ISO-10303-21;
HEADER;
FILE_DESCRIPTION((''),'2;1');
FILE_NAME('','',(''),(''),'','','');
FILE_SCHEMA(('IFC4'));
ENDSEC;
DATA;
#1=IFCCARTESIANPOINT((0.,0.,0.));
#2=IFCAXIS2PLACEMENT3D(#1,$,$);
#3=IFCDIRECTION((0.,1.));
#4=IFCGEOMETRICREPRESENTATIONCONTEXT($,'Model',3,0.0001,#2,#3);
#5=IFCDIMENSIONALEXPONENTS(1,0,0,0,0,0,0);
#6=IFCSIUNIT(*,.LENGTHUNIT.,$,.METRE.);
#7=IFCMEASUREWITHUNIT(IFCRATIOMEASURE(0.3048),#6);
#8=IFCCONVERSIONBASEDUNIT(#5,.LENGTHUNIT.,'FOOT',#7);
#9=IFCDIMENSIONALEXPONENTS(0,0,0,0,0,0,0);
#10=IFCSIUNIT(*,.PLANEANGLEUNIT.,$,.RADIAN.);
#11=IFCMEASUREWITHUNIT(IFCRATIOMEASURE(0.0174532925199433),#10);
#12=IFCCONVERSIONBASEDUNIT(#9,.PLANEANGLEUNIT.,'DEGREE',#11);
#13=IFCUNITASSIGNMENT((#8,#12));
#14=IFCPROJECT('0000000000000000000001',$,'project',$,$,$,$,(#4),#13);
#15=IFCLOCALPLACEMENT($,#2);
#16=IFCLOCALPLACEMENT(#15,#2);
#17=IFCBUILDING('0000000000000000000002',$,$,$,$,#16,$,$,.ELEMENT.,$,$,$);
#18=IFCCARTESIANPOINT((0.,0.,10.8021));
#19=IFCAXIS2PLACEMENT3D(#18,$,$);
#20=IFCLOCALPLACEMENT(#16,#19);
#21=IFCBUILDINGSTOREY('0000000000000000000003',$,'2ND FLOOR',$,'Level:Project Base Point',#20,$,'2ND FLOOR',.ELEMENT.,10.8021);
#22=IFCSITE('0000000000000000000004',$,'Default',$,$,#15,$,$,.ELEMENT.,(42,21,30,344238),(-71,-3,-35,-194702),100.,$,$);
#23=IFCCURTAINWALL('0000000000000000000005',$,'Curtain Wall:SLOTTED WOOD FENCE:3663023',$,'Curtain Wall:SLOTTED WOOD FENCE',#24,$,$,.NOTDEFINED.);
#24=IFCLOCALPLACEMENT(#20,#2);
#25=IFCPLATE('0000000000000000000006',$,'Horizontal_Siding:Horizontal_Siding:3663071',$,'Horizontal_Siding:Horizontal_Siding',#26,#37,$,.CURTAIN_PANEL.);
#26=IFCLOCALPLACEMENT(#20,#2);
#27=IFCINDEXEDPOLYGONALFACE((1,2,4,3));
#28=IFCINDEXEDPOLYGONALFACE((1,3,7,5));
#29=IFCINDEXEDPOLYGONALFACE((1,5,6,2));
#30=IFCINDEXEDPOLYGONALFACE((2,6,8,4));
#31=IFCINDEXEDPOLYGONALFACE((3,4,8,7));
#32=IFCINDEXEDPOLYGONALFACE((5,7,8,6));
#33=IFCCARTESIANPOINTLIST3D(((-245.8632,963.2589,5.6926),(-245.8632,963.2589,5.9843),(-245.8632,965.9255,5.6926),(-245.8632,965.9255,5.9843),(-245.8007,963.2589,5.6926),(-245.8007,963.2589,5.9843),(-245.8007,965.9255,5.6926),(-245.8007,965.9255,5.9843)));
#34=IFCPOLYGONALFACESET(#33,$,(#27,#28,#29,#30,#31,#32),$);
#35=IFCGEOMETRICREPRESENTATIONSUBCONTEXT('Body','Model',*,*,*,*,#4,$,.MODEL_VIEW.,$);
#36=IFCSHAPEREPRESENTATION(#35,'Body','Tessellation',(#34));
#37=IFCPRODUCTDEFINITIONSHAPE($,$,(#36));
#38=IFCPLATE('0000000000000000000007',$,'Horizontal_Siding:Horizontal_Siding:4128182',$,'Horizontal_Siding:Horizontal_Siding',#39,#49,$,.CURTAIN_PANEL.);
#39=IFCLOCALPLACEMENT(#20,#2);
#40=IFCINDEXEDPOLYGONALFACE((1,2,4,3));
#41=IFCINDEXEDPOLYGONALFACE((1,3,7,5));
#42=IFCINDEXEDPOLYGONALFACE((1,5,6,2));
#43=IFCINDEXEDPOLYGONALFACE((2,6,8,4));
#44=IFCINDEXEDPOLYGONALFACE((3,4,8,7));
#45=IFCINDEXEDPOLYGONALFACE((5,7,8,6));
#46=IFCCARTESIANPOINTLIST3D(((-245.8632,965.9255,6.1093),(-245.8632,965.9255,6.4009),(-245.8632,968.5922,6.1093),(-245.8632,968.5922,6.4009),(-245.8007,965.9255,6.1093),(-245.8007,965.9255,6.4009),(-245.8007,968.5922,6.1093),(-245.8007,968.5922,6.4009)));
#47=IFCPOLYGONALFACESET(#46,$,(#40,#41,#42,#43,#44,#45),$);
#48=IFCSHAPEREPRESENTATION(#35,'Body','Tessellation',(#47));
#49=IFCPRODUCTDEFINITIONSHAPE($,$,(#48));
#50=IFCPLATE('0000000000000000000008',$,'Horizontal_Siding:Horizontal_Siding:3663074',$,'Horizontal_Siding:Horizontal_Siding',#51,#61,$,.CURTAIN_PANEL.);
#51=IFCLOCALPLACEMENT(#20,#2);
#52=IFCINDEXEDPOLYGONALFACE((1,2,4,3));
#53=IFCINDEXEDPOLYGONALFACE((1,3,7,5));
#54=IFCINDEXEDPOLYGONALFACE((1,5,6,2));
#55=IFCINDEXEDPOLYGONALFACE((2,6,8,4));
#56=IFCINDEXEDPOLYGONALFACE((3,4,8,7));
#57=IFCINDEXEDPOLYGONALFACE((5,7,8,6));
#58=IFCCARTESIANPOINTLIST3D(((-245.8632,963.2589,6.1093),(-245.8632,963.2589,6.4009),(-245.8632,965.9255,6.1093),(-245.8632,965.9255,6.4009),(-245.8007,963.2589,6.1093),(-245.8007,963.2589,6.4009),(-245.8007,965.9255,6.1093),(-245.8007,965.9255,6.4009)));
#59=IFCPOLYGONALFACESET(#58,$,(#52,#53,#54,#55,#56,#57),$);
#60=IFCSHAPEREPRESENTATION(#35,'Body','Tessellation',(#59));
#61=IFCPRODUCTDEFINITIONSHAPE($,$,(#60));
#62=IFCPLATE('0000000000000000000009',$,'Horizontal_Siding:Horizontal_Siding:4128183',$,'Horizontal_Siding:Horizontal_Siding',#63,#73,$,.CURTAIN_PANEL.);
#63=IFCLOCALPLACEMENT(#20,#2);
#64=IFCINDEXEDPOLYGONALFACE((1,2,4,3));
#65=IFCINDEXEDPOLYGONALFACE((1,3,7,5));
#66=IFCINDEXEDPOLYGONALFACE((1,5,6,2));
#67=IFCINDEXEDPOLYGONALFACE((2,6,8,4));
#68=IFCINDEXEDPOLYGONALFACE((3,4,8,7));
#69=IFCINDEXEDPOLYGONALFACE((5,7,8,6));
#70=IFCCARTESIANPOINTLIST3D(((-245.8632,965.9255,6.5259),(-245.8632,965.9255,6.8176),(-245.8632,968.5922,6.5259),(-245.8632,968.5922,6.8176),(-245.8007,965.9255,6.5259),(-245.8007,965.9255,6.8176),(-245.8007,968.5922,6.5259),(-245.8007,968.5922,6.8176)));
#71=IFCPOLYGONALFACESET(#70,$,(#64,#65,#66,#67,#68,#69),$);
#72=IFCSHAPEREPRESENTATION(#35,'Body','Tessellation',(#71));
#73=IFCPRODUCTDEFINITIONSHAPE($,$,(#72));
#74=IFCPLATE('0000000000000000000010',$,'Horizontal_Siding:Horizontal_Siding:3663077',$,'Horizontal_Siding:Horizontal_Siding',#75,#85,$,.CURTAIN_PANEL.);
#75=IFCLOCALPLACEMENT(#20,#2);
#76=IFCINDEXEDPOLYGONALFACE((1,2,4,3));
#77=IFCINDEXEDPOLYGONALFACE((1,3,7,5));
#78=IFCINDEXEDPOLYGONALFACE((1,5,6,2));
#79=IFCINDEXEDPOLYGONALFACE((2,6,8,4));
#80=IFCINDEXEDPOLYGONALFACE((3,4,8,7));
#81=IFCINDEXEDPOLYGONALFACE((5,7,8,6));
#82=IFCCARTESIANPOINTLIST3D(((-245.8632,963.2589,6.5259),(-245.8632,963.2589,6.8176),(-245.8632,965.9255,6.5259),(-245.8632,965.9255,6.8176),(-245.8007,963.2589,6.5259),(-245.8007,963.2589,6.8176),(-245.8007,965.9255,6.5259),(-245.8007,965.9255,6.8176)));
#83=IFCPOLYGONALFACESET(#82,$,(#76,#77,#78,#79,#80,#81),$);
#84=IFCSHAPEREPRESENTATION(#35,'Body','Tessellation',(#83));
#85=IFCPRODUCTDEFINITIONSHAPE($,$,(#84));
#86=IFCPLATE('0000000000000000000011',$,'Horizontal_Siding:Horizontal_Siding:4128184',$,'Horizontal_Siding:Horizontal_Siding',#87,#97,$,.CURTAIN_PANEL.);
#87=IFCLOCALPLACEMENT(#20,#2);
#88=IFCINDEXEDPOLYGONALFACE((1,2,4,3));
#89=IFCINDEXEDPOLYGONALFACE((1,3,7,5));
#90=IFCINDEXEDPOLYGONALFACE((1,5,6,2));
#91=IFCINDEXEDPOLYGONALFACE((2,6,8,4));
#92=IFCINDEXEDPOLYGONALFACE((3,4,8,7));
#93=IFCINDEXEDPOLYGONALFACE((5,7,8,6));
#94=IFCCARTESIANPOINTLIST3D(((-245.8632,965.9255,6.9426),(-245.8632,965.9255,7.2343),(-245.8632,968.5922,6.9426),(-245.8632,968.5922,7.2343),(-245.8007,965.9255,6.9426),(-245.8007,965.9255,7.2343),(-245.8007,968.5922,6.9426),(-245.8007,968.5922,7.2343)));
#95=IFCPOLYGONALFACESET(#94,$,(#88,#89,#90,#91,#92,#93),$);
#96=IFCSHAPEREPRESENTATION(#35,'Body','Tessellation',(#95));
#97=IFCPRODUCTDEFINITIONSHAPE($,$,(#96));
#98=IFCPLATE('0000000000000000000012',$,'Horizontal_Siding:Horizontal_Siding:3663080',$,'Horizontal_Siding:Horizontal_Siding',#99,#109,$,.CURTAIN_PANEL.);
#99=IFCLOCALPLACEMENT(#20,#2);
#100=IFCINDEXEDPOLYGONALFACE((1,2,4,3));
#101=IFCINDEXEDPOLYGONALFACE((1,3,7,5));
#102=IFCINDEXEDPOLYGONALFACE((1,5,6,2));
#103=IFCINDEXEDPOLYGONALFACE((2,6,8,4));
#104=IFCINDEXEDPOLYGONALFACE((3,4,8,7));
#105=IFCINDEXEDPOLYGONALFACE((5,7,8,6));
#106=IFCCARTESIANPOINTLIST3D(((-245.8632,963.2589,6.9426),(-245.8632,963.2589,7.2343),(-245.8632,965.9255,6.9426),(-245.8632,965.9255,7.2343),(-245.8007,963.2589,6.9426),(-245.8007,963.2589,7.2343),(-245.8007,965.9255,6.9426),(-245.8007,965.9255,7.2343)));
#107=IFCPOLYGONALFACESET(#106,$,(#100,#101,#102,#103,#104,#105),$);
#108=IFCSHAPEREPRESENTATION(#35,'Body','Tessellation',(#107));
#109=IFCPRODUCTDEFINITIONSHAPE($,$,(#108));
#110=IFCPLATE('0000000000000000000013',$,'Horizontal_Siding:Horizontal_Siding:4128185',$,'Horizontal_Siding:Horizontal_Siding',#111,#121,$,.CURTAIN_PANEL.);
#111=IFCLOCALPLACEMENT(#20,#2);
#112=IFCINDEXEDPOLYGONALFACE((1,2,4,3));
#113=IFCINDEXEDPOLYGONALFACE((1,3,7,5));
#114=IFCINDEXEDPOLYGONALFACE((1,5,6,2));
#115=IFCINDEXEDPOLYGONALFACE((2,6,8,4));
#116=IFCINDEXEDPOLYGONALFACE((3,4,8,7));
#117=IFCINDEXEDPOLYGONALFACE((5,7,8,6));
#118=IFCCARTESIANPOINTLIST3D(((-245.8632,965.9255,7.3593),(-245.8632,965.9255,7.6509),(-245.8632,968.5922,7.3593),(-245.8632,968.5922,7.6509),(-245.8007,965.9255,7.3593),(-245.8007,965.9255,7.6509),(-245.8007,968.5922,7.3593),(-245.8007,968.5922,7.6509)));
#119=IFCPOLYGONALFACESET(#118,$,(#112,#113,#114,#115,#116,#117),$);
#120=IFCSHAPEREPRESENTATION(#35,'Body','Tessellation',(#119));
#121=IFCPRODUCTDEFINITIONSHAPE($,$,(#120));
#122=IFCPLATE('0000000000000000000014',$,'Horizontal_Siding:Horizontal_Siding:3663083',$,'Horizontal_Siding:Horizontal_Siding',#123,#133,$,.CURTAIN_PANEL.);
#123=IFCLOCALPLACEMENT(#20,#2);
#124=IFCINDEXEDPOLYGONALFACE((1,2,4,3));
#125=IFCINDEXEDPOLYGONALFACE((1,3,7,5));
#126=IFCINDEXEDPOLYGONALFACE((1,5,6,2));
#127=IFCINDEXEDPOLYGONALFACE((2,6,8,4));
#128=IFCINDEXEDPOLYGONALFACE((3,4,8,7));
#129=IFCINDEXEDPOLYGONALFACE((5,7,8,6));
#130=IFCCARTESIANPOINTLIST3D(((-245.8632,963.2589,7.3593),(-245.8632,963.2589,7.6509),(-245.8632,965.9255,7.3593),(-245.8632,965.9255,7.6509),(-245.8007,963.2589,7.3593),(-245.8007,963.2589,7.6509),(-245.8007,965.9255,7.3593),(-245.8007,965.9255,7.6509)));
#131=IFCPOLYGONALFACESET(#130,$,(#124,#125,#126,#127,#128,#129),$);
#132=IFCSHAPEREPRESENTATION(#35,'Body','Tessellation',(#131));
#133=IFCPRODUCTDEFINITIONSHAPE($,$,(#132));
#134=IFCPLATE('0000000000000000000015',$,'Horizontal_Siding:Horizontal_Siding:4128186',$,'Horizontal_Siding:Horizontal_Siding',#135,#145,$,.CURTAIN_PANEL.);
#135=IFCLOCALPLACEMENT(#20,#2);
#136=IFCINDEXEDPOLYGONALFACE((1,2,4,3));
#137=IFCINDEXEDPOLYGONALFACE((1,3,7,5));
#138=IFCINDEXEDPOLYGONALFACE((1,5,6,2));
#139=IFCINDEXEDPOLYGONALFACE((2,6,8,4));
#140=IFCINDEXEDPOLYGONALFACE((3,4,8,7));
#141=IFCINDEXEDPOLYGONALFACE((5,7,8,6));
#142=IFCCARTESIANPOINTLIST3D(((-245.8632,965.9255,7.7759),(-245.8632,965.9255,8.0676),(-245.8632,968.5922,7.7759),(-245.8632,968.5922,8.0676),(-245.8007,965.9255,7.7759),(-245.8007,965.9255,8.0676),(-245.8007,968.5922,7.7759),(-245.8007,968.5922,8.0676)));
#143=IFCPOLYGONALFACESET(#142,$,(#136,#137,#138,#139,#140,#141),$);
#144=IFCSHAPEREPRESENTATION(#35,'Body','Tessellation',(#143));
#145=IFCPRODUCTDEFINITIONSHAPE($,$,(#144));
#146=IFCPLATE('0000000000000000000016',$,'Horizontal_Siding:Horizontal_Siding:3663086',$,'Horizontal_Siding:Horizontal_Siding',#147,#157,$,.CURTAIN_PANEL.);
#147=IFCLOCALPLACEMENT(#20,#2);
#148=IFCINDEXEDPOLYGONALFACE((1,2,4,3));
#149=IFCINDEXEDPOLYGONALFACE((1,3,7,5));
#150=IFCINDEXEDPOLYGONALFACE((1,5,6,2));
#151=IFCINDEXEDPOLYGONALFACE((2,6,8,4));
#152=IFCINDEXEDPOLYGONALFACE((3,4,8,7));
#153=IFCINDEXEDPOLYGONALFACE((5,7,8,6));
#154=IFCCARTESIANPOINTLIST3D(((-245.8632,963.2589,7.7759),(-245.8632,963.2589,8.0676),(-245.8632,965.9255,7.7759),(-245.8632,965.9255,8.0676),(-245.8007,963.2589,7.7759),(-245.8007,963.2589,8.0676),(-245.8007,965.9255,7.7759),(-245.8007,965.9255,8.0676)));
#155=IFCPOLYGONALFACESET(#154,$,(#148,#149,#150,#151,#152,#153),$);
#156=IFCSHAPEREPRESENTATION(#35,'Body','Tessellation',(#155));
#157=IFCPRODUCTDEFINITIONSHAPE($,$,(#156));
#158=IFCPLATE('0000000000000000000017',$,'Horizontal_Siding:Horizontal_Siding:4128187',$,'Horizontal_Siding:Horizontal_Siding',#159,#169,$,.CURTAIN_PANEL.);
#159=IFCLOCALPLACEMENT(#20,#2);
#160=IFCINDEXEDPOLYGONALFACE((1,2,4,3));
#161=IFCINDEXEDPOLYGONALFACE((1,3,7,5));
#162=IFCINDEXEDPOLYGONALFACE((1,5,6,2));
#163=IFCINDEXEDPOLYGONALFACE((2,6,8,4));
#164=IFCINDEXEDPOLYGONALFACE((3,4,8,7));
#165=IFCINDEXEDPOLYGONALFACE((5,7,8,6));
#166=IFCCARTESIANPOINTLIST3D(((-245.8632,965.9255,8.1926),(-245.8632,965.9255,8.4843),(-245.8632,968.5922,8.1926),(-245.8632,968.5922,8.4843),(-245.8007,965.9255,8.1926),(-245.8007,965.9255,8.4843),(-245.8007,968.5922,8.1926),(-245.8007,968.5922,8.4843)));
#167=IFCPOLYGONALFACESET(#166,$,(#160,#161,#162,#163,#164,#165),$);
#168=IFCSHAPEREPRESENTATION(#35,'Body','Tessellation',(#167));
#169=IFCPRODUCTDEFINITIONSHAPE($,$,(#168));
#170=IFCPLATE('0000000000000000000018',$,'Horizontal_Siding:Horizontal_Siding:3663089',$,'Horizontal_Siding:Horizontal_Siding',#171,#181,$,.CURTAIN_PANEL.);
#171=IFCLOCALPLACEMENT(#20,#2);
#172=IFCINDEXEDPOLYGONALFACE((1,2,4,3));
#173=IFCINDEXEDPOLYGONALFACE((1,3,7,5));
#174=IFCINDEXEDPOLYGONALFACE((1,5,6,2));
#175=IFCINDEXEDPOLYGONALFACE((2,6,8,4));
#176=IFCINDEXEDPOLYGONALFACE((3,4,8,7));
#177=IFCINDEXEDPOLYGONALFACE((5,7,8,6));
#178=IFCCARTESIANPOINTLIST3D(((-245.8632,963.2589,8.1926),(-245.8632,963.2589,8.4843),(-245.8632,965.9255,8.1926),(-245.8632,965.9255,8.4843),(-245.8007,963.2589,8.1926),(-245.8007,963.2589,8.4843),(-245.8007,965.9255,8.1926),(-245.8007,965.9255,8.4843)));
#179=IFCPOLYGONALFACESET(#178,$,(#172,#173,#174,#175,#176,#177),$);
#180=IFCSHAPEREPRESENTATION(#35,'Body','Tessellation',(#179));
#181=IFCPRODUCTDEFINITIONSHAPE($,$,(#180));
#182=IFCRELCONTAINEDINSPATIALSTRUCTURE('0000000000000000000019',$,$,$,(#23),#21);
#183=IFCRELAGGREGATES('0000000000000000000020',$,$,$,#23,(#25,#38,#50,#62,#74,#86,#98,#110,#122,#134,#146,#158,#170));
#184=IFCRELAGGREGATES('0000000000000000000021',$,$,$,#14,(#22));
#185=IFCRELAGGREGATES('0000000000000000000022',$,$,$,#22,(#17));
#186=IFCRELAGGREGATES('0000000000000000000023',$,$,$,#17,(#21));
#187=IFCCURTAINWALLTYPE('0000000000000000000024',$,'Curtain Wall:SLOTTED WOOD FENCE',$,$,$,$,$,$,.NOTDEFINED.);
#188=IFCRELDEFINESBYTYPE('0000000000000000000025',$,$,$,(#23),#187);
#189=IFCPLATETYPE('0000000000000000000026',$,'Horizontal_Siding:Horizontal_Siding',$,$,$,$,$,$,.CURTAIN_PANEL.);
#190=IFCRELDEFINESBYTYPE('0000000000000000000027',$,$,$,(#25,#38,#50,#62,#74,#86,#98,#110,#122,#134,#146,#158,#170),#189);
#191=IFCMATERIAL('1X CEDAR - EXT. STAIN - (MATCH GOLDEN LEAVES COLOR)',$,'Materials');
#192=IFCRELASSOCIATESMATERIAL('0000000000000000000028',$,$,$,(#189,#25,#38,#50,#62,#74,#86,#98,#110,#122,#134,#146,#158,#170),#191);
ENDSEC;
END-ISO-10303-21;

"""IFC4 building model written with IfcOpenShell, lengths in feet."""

from ifc_helpers import new_model, entity, si_unit, converted_unit, direction, frame, origin, origin_2d_with_axis, place, context, subcontext, project, spatial, rectangle, extrude, source, transform, mapped, material, type_object, type_shapes, element, aggregate, save


model = new_model("IFC4")

# Units and contexts
model_context = context("Model", 3, precision=0.0001, world=origin(), true_north=direction((0.0, 1.0)))
body_context = subcontext(model_context, "Body", "Model", "MODEL_VIEW")
ifc_project = project(units=[converted_unit("LENGTHUNIT", "FOOT", entity("IfcRatioMeasure", 0.3048), si_unit("LENGTHUNIT", "METRE"), dimensions=[1, 0, 0, 0, 0, 0, 0]), converted_unit("PLANEANGLEUNIT", "DEGREE", entity("IfcRatioMeasure", 0.0174532925199433), si_unit("PLANEANGLEUNIT", "RADIAN"), dimensions=[0, 0, 0, 0, 0, 0, 0])], contexts=[model_context])

# Site, building, storey
site_placement = place(None, origin())
site = spatial("IfcSite", under=ifc_project, at=site_placement, Name="Default", CompositionType="ELEMENT", RefLatitude=(42, 21, 30, 344238), RefLongitude=(-71, -3, -35, -194702), RefElevation=100.0)
building_placement = place(site_placement, origin())
building = spatial("IfcBuilding", under=site, at=building_placement, CompositionType="ELEMENT")
storey_placement = place(building_placement, frame((0.0, 0.0, 10.8021)))
storey = spatial("IfcBuildingStorey", under=building, at=storey_placement, Name="2ND FLOOR", ObjectType="Level:Project Base Point", LongName="2ND FLOOR", CompositionType="ELEMENT", Elevation=10.8021)

# Curtain wall, plates
curtain_wall_type = type_object("IfcCurtainWallType", Name="Curtain Wall:SLOTTED WOOD FENCE", PredefinedType="NOTDEFINED")
curtain_wall_placement = place(storey_placement, frame((0.0, 0.0, -10.8021)))
curtain_wall = element("IfcCurtainWall", 1, at=curtain_wall_placement, inside=storey, type_object=curtain_wall_type, Name="Curtain Wall:SLOTTED WOOD FENCE:3663023", ObjectType="Curtain Wall:SLOTTED WOOD FENCE", PredefinedType="NOTDEFINED")
ifc_material_1 = material(Name="1X CEDAR - EXT. STAIN - (MATCH GOLDEN LEAVES COLOR)", Category="Materials")
plate_type_1 = type_object("IfcPlateType", Name="Horizontal_Siding:Horizontal_Siding", PredefinedType="CURTAIN_PANEL", material=ifc_material_1)
shared_shape_1 = source(origin(), body_context, "Body", "SweptSolid", [
    extrude(rectangle(XDim=0.0625, YDim=2.6667, at=origin_2d_with_axis()), frame((1.3333, 0.0312, 0.0), z_axis=(0.0, 0.0, 1.0), x_axis=(0.0, 1.0, 0.0)), (0.0, 0.0, 1.0), 0.2917),
])
type_shapes(plate_type_1, [shared_shape_1])
plate_1_placement = place(curtain_wall_placement, frame((-245.8632, 965.9255, 16.4947), z_axis=(0.0, 0.0, 1.0), x_axis=(0.0, -1.0, 0.0)))
plate_1 = element("IfcPlate", 2, at=plate_1_placement, type_object=plate_type_1, material=ifc_material_1, Name="Horizontal_Siding:Horizontal_Siding:3663071", ObjectType="Horizontal_Siding:Horizontal_Siding", PredefinedType="CURTAIN_PANEL", context=body_context, shape_type="MappedRepresentation", body=[
    mapped(shared_shape_1, transform((0.0, 0.0, 0.0), scale=1.0)),
])
plate_2_placement = place(curtain_wall_placement, frame((-245.8632, 968.5922, 16.9113), z_axis=(0.0, 0.0, 1.0), x_axis=(0.0, -1.0, 0.0)))
plate_2 = element("IfcPlate", 3, at=plate_2_placement, type_object=plate_type_1, material=ifc_material_1, Name="Horizontal_Siding:Horizontal_Siding:4128182", ObjectType="Horizontal_Siding:Horizontal_Siding", PredefinedType="CURTAIN_PANEL", context=body_context, shape_type="MappedRepresentation", body=[
    mapped(shared_shape_1, transform((0.0, 0.0, 0.0), scale=1.0)),
])
plate_3_placement = place(curtain_wall_placement, frame((-245.8632, 965.9255, 16.9113), z_axis=(0.0, 0.0, 1.0), x_axis=(0.0, -1.0, 0.0)))
plate_3 = element("IfcPlate", 4, at=plate_3_placement, type_object=plate_type_1, material=ifc_material_1, Name="Horizontal_Siding:Horizontal_Siding:3663074", ObjectType="Horizontal_Siding:Horizontal_Siding", PredefinedType="CURTAIN_PANEL", context=body_context, shape_type="MappedRepresentation", body=[
    mapped(shared_shape_1, transform((0.0, 0.0, 0.0), scale=1.0)),
])
plate_4_placement = place(curtain_wall_placement, frame((-245.8632, 968.5922, 17.328), z_axis=(0.0, 0.0, 1.0), x_axis=(0.0, -1.0, 0.0)))
plate_4 = element("IfcPlate", 5, at=plate_4_placement, type_object=plate_type_1, material=ifc_material_1, Name="Horizontal_Siding:Horizontal_Siding:4128183", ObjectType="Horizontal_Siding:Horizontal_Siding", PredefinedType="CURTAIN_PANEL", context=body_context, shape_type="MappedRepresentation", body=[
    mapped(shared_shape_1, transform((0.0, 0.0, 0.0), scale=1.0)),
])
plate_5_placement = place(curtain_wall_placement, frame((-245.8632, 965.9255, 17.328), z_axis=(0.0, 0.0, 1.0), x_axis=(0.0, -1.0, 0.0)))
plate_5 = element("IfcPlate", 6, at=plate_5_placement, type_object=plate_type_1, material=ifc_material_1, Name="Horizontal_Siding:Horizontal_Siding:3663077", ObjectType="Horizontal_Siding:Horizontal_Siding", PredefinedType="CURTAIN_PANEL", context=body_context, shape_type="MappedRepresentation", body=[
    mapped(shared_shape_1, transform((0.0, 0.0, 0.0), scale=1.0)),
])
plate_6_placement = place(curtain_wall_placement, frame((-245.8632, 968.5922, 17.7447), z_axis=(0.0, 0.0, 1.0), x_axis=(0.0, -1.0, 0.0)))
plate_6 = element("IfcPlate", 7, at=plate_6_placement, type_object=plate_type_1, material=ifc_material_1, Name="Horizontal_Siding:Horizontal_Siding:4128184", ObjectType="Horizontal_Siding:Horizontal_Siding", PredefinedType="CURTAIN_PANEL", context=body_context, shape_type="MappedRepresentation", body=[
    mapped(shared_shape_1, transform((0.0, 0.0, 0.0), scale=1.0)),
])
plate_7_placement = place(curtain_wall_placement, frame((-245.8632, 965.9255, 17.7447), z_axis=(0.0, 0.0, 1.0), x_axis=(0.0, -1.0, 0.0)))
plate_7 = element("IfcPlate", 8, at=plate_7_placement, type_object=plate_type_1, material=ifc_material_1, Name="Horizontal_Siding:Horizontal_Siding:3663080", ObjectType="Horizontal_Siding:Horizontal_Siding", PredefinedType="CURTAIN_PANEL", context=body_context, shape_type="MappedRepresentation", body=[
    mapped(shared_shape_1, transform((0.0, 0.0, 0.0), scale=1.0)),
])
plate_8_placement = place(curtain_wall_placement, frame((-245.8632, 968.5922, 18.1613), z_axis=(0.0, 0.0, 1.0), x_axis=(0.0, -1.0, 0.0)))
plate_8 = element("IfcPlate", 9, at=plate_8_placement, type_object=plate_type_1, material=ifc_material_1, Name="Horizontal_Siding:Horizontal_Siding:4128185", ObjectType="Horizontal_Siding:Horizontal_Siding", PredefinedType="CURTAIN_PANEL", context=body_context, shape_type="MappedRepresentation", body=[
    mapped(shared_shape_1, transform((0.0, 0.0, 0.0), scale=1.0)),
])
plate_9_placement = place(curtain_wall_placement, frame((-245.8632, 965.9255, 18.1613), z_axis=(0.0, 0.0, 1.0), x_axis=(0.0, -1.0, 0.0)))
plate_9 = element("IfcPlate", 10, at=plate_9_placement, type_object=plate_type_1, material=ifc_material_1, Name="Horizontal_Siding:Horizontal_Siding:3663083", ObjectType="Horizontal_Siding:Horizontal_Siding", PredefinedType="CURTAIN_PANEL", context=body_context, shape_type="MappedRepresentation", body=[
    mapped(shared_shape_1, transform((0.0, 0.0, 0.0), scale=1.0)),
])
plate_10_placement = place(curtain_wall_placement, frame((-245.8632, 968.5922, 18.578), z_axis=(0.0, 0.0, 1.0), x_axis=(0.0, -1.0, 0.0)))
plate_10 = element("IfcPlate", 11, at=plate_10_placement, type_object=plate_type_1, material=ifc_material_1, Name="Horizontal_Siding:Horizontal_Siding:4128186", ObjectType="Horizontal_Siding:Horizontal_Siding", PredefinedType="CURTAIN_PANEL", context=body_context, shape_type="MappedRepresentation", body=[
    mapped(shared_shape_1, transform((0.0, 0.0, 0.0), scale=1.0)),
])
plate_11_placement = place(curtain_wall_placement, frame((-245.8632, 965.9255, 18.578), z_axis=(0.0, 0.0, 1.0), x_axis=(0.0, -1.0, 0.0)))
plate_11 = element("IfcPlate", 12, at=plate_11_placement, type_object=plate_type_1, material=ifc_material_1, Name="Horizontal_Siding:Horizontal_Siding:3663086", ObjectType="Horizontal_Siding:Horizontal_Siding", PredefinedType="CURTAIN_PANEL", context=body_context, shape_type="MappedRepresentation", body=[
    mapped(shared_shape_1, transform((0.0, 0.0, 0.0), scale=1.0)),
])
plate_12_placement = place(curtain_wall_placement, frame((-245.8632, 968.5922, 18.9947), z_axis=(0.0, 0.0, 1.0), x_axis=(0.0, -1.0, 0.0)))
plate_12 = element("IfcPlate", 13, at=plate_12_placement, type_object=plate_type_1, material=ifc_material_1, Name="Horizontal_Siding:Horizontal_Siding:4128187", ObjectType="Horizontal_Siding:Horizontal_Siding", PredefinedType="CURTAIN_PANEL", context=body_context, shape_type="MappedRepresentation", body=[
    mapped(shared_shape_1, transform((0.0, 0.0, 0.0), scale=1.0)),
])
plate_13_placement = place(curtain_wall_placement, frame((-245.8632, 965.9255, 18.9947), z_axis=(0.0, 0.0, 1.0), x_axis=(0.0, -1.0, 0.0)))
plate_13 = element("IfcPlate", 14, at=plate_13_placement, type_object=plate_type_1, material=ifc_material_1, Name="Horizontal_Siding:Horizontal_Siding:3663089", ObjectType="Horizontal_Siding:Horizontal_Siding", PredefinedType="CURTAIN_PANEL", context=body_context, shape_type="MappedRepresentation", body=[
    mapped(shared_shape_1, transform((0.0, 0.0, 0.0), scale=1.0)),
])
aggregate(curtain_wall, [plate_1, plate_2, plate_3, plate_4, plate_5, plate_6, plate_7, plate_8, plate_9, plate_10, plate_11, plate_12, plate_13])

save(model, "model.ifc")
